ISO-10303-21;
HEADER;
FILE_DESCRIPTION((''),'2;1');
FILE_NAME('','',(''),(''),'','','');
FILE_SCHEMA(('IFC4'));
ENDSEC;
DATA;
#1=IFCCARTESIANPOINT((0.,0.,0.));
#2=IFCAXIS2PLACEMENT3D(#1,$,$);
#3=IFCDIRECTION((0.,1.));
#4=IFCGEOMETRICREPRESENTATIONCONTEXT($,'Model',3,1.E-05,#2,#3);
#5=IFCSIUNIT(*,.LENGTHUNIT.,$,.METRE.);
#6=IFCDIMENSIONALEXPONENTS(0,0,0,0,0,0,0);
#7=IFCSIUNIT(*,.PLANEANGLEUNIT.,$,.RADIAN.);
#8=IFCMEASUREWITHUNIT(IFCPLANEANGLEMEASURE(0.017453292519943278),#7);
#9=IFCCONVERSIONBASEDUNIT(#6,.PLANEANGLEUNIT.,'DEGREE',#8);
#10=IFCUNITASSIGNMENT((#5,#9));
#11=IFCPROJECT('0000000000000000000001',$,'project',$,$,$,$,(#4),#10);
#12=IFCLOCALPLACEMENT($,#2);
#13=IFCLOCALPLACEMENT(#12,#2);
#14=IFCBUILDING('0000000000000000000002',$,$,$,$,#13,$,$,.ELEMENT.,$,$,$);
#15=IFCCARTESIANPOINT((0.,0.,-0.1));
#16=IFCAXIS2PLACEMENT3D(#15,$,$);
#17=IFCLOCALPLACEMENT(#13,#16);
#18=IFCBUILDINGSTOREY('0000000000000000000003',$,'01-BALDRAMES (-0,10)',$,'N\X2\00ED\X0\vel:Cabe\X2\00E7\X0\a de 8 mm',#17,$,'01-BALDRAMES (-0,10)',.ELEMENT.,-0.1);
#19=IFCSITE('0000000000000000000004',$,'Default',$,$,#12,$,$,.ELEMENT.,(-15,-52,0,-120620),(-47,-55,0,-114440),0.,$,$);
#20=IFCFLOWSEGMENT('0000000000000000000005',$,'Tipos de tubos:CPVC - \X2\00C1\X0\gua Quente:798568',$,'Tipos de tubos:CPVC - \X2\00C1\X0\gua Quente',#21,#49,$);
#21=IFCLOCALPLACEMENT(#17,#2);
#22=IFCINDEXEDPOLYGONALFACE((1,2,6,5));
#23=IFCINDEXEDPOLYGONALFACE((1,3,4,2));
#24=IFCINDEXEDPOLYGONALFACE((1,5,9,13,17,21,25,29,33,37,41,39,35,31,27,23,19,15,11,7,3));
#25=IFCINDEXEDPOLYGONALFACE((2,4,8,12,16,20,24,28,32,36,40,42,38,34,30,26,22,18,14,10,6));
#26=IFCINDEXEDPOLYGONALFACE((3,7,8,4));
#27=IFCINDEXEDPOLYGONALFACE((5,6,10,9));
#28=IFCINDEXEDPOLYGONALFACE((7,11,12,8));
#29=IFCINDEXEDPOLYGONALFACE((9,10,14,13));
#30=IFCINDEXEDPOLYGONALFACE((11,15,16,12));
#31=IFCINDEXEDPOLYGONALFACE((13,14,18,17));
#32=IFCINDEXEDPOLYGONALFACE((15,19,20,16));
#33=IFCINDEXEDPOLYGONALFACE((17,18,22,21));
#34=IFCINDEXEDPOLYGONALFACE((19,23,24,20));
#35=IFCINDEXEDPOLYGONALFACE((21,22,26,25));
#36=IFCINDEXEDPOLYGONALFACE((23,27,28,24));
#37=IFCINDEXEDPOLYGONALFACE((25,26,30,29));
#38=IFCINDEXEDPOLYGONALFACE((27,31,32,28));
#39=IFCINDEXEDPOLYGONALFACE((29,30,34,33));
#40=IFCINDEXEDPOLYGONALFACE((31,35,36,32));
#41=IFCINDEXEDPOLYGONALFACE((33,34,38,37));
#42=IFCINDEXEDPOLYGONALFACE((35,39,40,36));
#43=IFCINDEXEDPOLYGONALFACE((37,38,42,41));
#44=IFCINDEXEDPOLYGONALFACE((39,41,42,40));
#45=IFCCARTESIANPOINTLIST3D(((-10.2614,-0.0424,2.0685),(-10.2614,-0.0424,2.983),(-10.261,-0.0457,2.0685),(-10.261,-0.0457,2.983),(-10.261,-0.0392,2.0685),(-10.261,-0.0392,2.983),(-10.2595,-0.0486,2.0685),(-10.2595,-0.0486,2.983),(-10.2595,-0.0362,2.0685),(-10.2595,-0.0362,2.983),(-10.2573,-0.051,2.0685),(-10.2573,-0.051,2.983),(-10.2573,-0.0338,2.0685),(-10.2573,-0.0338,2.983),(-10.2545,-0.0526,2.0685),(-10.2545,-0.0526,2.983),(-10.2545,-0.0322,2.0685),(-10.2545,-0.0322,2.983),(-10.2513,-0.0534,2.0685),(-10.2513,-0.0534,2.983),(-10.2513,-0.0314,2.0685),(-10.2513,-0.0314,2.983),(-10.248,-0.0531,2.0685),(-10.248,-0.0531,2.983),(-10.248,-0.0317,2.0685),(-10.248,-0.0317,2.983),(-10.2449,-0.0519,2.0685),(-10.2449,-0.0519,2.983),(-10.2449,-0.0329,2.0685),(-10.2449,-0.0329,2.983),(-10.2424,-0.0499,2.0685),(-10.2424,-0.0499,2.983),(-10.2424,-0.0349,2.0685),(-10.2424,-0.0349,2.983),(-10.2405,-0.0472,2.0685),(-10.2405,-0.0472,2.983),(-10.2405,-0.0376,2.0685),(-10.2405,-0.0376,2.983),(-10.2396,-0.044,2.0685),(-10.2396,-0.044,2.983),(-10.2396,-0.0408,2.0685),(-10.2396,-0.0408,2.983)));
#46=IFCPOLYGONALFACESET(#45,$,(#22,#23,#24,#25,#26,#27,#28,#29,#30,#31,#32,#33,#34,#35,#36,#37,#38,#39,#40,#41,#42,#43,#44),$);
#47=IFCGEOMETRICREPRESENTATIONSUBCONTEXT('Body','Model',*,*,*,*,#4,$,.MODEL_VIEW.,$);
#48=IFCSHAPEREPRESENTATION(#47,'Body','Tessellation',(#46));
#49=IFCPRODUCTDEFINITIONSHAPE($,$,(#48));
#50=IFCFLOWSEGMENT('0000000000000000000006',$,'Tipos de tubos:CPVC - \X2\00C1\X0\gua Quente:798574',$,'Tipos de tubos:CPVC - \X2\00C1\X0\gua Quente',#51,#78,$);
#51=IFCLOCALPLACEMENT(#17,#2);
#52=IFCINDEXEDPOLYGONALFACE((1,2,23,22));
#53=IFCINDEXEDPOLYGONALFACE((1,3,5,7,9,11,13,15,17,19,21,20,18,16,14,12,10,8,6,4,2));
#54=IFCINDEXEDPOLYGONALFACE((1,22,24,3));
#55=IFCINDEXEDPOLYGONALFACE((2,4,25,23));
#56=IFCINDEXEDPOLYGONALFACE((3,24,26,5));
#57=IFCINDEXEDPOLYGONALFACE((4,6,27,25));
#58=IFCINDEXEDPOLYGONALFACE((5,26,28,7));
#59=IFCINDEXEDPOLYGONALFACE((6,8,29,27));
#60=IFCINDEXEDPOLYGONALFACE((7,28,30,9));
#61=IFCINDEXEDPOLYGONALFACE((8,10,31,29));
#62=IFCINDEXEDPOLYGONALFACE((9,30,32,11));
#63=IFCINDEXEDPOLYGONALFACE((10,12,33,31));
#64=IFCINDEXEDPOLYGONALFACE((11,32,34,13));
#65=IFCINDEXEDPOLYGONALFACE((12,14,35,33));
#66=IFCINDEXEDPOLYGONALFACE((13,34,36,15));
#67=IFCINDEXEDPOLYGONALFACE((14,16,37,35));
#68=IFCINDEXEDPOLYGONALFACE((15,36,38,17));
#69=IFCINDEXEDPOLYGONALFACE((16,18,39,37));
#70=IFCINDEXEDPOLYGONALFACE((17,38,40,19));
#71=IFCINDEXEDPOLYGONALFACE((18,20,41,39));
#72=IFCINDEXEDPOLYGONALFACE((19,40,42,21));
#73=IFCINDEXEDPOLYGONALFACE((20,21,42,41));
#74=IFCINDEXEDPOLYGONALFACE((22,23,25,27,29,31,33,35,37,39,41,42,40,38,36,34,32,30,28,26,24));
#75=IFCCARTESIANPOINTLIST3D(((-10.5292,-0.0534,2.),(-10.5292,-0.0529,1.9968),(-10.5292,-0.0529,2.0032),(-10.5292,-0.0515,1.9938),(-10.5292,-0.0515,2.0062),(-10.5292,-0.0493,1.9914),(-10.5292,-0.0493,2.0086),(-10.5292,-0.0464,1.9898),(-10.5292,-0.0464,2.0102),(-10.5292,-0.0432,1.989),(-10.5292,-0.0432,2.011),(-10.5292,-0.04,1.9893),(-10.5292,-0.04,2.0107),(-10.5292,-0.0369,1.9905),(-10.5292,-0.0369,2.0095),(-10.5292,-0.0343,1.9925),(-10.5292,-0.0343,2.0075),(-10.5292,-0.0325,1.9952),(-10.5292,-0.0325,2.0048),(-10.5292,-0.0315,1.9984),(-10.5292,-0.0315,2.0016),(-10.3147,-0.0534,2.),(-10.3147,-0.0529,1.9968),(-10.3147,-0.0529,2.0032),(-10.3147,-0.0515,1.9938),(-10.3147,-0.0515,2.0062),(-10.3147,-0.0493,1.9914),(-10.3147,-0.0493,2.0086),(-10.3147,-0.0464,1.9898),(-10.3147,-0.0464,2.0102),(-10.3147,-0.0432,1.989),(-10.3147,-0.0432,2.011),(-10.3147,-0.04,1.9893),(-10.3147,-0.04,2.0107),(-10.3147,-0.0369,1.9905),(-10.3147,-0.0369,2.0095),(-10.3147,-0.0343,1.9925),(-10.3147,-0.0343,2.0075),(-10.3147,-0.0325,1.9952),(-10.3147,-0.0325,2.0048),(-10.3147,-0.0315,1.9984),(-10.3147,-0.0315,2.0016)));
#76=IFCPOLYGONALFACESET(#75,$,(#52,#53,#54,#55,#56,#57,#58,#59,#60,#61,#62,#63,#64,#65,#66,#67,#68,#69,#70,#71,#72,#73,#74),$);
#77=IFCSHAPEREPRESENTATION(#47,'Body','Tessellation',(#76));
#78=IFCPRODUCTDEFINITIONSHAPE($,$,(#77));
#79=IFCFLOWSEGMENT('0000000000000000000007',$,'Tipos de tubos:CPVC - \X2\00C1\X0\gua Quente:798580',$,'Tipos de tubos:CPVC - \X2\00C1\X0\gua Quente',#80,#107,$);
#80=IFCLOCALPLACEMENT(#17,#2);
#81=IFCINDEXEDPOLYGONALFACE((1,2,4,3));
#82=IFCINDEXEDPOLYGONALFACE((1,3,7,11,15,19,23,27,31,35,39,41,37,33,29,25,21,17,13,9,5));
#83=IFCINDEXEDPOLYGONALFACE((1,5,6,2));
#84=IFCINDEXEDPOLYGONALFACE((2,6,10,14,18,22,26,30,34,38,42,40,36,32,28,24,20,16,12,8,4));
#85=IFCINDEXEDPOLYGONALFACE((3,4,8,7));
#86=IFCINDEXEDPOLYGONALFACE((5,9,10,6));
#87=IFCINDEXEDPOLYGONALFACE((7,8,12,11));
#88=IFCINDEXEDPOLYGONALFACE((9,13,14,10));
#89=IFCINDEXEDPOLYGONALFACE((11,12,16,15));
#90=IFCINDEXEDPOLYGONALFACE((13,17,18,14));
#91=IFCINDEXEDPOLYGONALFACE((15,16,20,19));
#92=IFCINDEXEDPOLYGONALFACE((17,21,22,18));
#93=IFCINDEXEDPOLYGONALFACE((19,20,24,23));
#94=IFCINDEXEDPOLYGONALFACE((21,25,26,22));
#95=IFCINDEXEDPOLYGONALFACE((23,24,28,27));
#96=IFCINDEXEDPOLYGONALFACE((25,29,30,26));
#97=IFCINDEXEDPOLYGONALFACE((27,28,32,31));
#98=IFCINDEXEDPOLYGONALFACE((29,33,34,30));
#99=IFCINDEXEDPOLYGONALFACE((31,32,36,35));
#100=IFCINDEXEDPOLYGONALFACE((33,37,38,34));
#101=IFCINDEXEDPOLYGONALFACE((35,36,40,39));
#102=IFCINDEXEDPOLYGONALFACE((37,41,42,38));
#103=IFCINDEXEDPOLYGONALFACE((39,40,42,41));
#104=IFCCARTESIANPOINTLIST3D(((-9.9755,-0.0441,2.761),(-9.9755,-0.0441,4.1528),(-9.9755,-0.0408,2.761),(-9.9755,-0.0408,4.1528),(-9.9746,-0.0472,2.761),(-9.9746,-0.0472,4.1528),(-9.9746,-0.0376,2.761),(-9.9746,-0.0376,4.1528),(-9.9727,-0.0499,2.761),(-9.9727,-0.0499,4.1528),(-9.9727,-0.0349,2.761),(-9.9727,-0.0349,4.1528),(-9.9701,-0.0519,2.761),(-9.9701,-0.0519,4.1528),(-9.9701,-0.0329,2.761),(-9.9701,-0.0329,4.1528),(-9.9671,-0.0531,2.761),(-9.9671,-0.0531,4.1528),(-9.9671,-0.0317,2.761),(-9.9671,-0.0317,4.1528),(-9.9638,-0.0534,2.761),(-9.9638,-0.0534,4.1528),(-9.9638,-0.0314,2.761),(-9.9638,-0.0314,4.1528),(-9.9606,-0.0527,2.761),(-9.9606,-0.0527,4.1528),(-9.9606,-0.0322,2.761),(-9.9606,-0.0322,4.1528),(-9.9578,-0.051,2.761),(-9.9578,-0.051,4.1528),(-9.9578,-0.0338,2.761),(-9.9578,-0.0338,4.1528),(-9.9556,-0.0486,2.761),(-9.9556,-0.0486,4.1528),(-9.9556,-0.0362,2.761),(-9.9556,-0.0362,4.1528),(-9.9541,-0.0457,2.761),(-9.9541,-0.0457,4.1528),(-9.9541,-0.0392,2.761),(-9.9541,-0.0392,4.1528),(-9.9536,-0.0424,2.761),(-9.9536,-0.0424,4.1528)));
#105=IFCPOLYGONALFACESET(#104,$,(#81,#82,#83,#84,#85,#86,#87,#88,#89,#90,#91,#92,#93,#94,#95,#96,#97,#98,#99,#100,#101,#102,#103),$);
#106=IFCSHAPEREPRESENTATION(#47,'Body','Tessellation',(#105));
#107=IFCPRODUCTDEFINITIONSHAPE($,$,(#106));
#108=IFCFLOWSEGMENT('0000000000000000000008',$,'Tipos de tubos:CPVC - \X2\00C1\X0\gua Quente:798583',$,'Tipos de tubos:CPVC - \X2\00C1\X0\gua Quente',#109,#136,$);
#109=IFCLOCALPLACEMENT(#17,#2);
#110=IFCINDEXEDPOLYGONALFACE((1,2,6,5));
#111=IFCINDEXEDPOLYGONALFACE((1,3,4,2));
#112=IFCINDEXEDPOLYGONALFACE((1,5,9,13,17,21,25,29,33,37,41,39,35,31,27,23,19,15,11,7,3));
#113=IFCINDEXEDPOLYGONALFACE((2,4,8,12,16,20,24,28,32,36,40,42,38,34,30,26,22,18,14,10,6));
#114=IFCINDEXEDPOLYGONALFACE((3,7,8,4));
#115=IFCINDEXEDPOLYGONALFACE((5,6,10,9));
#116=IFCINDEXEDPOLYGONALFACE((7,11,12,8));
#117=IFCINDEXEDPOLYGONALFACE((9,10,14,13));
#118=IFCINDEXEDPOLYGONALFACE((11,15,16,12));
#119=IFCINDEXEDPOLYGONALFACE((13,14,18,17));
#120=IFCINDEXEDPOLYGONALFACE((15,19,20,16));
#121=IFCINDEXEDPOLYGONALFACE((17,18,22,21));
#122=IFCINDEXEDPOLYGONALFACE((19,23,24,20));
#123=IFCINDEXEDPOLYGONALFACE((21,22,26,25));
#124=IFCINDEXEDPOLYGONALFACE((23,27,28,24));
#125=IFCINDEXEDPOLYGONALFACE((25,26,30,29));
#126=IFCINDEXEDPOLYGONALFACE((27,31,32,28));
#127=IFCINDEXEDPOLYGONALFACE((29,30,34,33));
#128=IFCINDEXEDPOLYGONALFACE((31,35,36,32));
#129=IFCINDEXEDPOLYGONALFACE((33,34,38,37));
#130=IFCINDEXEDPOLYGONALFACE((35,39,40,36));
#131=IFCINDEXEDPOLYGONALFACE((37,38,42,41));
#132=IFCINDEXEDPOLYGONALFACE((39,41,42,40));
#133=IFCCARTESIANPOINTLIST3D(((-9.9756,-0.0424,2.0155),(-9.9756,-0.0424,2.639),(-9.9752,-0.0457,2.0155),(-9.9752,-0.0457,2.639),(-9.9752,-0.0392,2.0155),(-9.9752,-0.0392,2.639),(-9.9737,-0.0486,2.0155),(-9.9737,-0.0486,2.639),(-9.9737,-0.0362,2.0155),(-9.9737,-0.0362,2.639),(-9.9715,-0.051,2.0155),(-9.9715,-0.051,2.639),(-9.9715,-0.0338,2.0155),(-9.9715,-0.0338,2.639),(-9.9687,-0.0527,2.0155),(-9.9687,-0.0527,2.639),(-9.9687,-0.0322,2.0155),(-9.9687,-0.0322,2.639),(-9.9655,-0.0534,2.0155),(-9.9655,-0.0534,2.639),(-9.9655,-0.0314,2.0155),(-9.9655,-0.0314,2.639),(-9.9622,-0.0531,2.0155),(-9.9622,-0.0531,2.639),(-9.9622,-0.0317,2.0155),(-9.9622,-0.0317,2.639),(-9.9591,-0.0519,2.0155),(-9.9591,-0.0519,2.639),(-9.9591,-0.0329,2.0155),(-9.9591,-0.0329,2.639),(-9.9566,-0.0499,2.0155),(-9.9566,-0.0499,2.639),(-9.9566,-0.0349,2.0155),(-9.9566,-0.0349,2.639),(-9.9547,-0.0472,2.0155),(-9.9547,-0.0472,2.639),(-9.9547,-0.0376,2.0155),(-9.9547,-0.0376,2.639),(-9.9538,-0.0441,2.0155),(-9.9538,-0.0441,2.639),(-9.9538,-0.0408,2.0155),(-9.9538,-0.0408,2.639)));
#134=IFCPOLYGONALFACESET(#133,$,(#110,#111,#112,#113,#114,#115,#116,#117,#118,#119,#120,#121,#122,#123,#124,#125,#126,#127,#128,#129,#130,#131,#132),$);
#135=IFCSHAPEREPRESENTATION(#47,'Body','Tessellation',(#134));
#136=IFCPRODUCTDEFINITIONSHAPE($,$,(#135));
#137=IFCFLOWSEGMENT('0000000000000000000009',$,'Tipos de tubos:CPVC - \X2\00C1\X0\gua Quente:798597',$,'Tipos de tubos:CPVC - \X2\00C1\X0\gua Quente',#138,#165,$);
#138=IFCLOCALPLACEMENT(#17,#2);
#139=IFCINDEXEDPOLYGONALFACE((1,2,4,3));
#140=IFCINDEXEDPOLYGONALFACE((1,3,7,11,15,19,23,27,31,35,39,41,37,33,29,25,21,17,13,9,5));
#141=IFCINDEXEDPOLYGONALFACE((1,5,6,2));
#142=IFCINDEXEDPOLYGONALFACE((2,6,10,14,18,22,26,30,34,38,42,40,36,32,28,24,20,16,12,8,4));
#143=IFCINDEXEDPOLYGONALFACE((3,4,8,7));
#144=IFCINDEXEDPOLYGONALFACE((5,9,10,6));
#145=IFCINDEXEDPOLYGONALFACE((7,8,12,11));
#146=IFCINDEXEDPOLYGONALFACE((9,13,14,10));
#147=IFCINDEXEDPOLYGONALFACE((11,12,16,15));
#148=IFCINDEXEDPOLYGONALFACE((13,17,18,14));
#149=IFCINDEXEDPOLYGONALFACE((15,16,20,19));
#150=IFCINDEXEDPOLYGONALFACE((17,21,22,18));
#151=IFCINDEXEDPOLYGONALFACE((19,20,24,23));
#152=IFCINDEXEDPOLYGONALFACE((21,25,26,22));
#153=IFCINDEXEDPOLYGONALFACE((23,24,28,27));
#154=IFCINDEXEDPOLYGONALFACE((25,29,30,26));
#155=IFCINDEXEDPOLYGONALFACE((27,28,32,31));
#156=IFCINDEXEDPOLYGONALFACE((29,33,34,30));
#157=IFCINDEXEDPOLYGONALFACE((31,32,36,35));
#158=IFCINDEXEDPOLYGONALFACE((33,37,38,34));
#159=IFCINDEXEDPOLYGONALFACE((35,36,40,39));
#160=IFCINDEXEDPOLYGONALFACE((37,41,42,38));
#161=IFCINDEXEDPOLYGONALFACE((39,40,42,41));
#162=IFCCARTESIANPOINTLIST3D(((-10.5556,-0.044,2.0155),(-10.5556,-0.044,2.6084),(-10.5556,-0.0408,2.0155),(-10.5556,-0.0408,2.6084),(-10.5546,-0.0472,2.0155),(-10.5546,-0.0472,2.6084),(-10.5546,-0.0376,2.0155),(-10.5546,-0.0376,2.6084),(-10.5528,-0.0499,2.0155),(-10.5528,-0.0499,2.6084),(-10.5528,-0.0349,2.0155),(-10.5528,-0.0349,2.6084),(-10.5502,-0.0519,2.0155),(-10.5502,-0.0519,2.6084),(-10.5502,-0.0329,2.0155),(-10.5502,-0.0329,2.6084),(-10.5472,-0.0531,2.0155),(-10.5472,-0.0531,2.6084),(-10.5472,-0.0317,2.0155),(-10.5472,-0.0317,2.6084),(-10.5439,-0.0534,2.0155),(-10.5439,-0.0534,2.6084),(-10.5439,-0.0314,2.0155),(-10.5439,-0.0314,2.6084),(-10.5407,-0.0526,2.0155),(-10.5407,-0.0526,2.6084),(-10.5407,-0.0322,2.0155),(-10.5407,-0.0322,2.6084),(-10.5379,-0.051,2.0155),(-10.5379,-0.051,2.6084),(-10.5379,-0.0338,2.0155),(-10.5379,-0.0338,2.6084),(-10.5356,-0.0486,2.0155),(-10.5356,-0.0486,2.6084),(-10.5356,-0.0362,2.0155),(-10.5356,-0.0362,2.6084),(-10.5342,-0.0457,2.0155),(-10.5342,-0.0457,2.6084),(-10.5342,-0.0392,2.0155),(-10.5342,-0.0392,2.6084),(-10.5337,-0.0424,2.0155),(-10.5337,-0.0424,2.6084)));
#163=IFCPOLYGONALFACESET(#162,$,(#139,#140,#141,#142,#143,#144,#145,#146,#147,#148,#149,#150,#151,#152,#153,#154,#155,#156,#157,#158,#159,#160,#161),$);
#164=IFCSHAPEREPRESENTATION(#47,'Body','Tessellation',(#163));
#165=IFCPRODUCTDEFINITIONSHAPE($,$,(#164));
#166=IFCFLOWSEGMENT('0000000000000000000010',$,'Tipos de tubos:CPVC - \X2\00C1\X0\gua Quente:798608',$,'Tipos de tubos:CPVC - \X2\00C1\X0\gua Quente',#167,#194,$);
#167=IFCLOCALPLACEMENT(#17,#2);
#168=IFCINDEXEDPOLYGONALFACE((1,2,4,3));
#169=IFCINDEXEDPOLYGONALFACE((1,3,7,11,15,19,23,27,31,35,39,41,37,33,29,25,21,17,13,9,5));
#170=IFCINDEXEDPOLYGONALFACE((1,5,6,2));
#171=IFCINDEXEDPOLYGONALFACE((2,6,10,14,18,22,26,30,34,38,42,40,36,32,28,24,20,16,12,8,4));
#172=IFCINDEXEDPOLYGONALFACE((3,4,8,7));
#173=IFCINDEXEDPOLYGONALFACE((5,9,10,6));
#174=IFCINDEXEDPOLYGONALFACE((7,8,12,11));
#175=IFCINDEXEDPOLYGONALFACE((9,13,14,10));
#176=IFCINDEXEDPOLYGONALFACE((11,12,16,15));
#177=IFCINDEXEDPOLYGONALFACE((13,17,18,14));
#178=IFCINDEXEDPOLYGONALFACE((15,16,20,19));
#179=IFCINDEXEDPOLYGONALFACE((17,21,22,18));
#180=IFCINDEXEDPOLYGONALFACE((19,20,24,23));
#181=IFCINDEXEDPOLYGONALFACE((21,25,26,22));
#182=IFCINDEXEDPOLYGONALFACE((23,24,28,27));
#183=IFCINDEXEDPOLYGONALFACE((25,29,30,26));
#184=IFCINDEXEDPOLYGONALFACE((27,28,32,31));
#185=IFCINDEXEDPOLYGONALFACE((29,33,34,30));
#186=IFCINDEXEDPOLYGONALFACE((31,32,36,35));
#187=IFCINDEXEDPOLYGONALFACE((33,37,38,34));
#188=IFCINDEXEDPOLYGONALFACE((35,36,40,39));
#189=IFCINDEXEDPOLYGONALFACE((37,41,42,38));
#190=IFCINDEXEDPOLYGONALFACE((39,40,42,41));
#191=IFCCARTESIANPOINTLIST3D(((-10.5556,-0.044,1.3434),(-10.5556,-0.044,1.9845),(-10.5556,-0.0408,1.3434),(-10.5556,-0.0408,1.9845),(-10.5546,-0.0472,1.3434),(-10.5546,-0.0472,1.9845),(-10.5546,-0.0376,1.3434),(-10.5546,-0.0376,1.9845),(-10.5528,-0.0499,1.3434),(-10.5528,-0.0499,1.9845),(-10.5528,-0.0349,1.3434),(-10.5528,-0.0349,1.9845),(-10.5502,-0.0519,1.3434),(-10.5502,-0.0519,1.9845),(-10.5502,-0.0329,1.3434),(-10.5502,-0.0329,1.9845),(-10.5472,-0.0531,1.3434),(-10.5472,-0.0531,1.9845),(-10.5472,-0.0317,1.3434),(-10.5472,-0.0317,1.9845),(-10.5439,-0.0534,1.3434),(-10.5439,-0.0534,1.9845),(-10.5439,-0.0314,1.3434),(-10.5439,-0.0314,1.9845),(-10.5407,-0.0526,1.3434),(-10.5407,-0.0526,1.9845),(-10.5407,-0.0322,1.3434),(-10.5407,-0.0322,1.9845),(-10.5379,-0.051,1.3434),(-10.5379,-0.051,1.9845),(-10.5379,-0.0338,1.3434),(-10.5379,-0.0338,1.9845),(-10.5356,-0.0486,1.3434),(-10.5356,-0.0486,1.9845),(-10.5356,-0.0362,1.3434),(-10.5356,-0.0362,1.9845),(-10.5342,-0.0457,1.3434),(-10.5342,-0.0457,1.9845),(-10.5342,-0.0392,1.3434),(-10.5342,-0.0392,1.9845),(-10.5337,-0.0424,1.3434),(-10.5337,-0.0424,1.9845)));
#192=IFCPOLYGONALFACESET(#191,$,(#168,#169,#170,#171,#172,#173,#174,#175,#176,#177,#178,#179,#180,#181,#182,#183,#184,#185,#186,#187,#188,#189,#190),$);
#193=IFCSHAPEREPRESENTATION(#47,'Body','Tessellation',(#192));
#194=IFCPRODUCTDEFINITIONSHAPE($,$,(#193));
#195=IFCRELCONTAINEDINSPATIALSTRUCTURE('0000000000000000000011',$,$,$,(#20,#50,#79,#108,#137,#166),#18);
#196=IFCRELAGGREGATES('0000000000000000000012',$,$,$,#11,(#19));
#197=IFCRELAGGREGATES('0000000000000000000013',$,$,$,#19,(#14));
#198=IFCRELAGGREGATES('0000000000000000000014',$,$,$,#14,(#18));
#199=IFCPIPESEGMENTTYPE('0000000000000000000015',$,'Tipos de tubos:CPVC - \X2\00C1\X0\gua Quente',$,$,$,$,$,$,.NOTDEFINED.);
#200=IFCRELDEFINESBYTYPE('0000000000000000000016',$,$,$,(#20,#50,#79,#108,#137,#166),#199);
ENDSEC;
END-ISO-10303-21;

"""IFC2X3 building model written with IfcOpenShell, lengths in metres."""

from ifc_helpers import new_model, entity, si_unit, converted_unit, direction, frame, frame_2d, origin, place, context, subcontext, project, spatial, circle, extrude, type_object, element, save


model = new_model("IFC2X3")

# Units and contexts
model_context = context("Model", 3, precision=1e-05, world=origin(), true_north=direction((0.0, 1.0)))
body_context = subcontext(model_context, "Body", "Model", "MODEL_VIEW")
ifc_project = project(units=[si_unit("LENGTHUNIT", "METRE"), converted_unit("PLANEANGLEUNIT", "DEGREE", entity("IfcPlaneAngleMeasure", 0.017453292519943278), si_unit("PLANEANGLEUNIT", "RADIAN"), dimensions=[0, 0, 0, 0, 0, 0, 0])], contexts=[model_context])

# Site, building, storey
site_placement = place(None, origin())
site = spatial("IfcSite", under=ifc_project, at=site_placement, Name="Default", CompositionType="ELEMENT", RefLatitude=(-15, -52, 0, -120620), RefLongitude=(-47, -55, 0, -114440), RefElevation=0.0)
building_placement = place(site_placement, origin())
building = spatial("IfcBuilding", under=site, at=building_placement, CompositionType="ELEMENT")
storey_placement = place(building_placement, frame((0.0, 0.0, -0.1)))
storey = spatial("IfcBuildingStorey", under=building, at=storey_placement, Name="01-BALDRAMES (-0,10)", ObjectType="Nível:Cabeça de 8 mm", LongName="01-BALDRAMES (-0,10)", CompositionType="ELEMENT", Elevation=-0.1)

# Flow segments
pipe_segment_type_1 = type_object("IfcPipeSegmentType", Name="Tipos de tubos:CPVC - Água Quente", PredefinedType="NOTDEFINED")
flow_segment_1_placement = place(storey_placement, origin())
element("IfcFlowSegment", 1, at=flow_segment_1_placement, inside=storey, type_object=pipe_segment_type_1, Name="Tipos de tubos:CPVC - Água Quente:798568", ObjectType="Tipos de tubos:CPVC - Água Quente", context=body_context, shape_type="SweptSolid", body=[
    extrude(circle(Radius=0.011, at=frame_2d((0.0, 0.0), x_axis=(1.0, 0.0))), frame((-10.2504, -0.0424, 2.0685), z_axis=(0.0, 0.0, 1.0), x_axis=(-1.0, 0.0, 0.0)), (0.0, 0.0, 1.0), 0.9145),
])
flow_segment_2_placement = place(storey_placement, origin())
element("IfcFlowSegment", 2, at=flow_segment_2_placement, inside=storey, type_object=pipe_segment_type_1, Name="Tipos de tubos:CPVC - Água Quente:798574", ObjectType="Tipos de tubos:CPVC - Água Quente", context=body_context, shape_type="SweptSolid", body=[
    extrude(circle(Radius=0.011, at=frame_2d((0.0, 0.0), x_axis=(1.0, 0.0))), frame((-10.5292, -0.0424, 2.0), z_axis=(1.0, -0.000004, 0.0), x_axis=(-0.000004, -1.0, 0.0)), (0.0, 0.0, 1.0), 0.2145),
])
flow_segment_3_placement = place(storey_placement, origin())
element("IfcFlowSegment", 3, at=flow_segment_3_placement, inside=storey, type_object=pipe_segment_type_1, Name="Tipos de tubos:CPVC - Água Quente:798580", ObjectType="Tipos de tubos:CPVC - Água Quente", context=body_context, shape_type="SweptSolid", body=[
    extrude(circle(Radius=0.011, at=frame_2d((0.0, 0.0), x_axis=(1.0, 0.0))), frame((-9.9646, -0.0424, 2.761)), (0.0, 0.0, 1.0), 1.3918),
])
flow_segment_4_placement = place(storey_placement, origin())
element("IfcFlowSegment", 4, at=flow_segment_4_placement, inside=storey, type_object=pipe_segment_type_1, Name="Tipos de tubos:CPVC - Água Quente:798583", ObjectType="Tipos de tubos:CPVC - Água Quente", context=body_context, shape_type="SweptSolid", body=[
    extrude(circle(Radius=0.011, at=frame_2d((0.0, 0.0), x_axis=(1.0, 0.0))), frame((-9.9646, -0.0424, 2.0155), z_axis=(0.0, 0.0, 1.0), x_axis=(-1.0, 0.0, 0.0)), (0.0, 0.0, 1.0), 0.6235),
])
flow_segment_5_placement = place(storey_placement, origin())
element("IfcFlowSegment", 5, at=flow_segment_5_placement, inside=storey, type_object=pipe_segment_type_1, Name="Tipos de tubos:CPVC - Água Quente:798597", ObjectType="Tipos de tubos:CPVC - Água Quente", context=body_context, shape_type="SweptSolid", body=[
    extrude(circle(Radius=0.011, at=frame_2d((0.0, 0.0), x_axis=(1.0, 0.0))), frame((-10.5447, -0.0424, 2.0155)), (0.0, 0.0, 1.0), 0.5929),
])
flow_segment_6_placement = place(storey_placement, origin())
element("IfcFlowSegment", 6, at=flow_segment_6_placement, inside=storey, type_object=pipe_segment_type_1, Name="Tipos de tubos:CPVC - Água Quente:798608", ObjectType="Tipos de tubos:CPVC - Água Quente", context=body_context, shape_type="SweptSolid", body=[
    extrude(circle(Radius=0.011, at=frame_2d((0.0, 0.0), x_axis=(1.0, 0.0))), frame((-10.5447, -0.0424, 1.3434)), (0.0, 0.0, 1.0), 0.6411),
])

save(model, "model.ifc")
